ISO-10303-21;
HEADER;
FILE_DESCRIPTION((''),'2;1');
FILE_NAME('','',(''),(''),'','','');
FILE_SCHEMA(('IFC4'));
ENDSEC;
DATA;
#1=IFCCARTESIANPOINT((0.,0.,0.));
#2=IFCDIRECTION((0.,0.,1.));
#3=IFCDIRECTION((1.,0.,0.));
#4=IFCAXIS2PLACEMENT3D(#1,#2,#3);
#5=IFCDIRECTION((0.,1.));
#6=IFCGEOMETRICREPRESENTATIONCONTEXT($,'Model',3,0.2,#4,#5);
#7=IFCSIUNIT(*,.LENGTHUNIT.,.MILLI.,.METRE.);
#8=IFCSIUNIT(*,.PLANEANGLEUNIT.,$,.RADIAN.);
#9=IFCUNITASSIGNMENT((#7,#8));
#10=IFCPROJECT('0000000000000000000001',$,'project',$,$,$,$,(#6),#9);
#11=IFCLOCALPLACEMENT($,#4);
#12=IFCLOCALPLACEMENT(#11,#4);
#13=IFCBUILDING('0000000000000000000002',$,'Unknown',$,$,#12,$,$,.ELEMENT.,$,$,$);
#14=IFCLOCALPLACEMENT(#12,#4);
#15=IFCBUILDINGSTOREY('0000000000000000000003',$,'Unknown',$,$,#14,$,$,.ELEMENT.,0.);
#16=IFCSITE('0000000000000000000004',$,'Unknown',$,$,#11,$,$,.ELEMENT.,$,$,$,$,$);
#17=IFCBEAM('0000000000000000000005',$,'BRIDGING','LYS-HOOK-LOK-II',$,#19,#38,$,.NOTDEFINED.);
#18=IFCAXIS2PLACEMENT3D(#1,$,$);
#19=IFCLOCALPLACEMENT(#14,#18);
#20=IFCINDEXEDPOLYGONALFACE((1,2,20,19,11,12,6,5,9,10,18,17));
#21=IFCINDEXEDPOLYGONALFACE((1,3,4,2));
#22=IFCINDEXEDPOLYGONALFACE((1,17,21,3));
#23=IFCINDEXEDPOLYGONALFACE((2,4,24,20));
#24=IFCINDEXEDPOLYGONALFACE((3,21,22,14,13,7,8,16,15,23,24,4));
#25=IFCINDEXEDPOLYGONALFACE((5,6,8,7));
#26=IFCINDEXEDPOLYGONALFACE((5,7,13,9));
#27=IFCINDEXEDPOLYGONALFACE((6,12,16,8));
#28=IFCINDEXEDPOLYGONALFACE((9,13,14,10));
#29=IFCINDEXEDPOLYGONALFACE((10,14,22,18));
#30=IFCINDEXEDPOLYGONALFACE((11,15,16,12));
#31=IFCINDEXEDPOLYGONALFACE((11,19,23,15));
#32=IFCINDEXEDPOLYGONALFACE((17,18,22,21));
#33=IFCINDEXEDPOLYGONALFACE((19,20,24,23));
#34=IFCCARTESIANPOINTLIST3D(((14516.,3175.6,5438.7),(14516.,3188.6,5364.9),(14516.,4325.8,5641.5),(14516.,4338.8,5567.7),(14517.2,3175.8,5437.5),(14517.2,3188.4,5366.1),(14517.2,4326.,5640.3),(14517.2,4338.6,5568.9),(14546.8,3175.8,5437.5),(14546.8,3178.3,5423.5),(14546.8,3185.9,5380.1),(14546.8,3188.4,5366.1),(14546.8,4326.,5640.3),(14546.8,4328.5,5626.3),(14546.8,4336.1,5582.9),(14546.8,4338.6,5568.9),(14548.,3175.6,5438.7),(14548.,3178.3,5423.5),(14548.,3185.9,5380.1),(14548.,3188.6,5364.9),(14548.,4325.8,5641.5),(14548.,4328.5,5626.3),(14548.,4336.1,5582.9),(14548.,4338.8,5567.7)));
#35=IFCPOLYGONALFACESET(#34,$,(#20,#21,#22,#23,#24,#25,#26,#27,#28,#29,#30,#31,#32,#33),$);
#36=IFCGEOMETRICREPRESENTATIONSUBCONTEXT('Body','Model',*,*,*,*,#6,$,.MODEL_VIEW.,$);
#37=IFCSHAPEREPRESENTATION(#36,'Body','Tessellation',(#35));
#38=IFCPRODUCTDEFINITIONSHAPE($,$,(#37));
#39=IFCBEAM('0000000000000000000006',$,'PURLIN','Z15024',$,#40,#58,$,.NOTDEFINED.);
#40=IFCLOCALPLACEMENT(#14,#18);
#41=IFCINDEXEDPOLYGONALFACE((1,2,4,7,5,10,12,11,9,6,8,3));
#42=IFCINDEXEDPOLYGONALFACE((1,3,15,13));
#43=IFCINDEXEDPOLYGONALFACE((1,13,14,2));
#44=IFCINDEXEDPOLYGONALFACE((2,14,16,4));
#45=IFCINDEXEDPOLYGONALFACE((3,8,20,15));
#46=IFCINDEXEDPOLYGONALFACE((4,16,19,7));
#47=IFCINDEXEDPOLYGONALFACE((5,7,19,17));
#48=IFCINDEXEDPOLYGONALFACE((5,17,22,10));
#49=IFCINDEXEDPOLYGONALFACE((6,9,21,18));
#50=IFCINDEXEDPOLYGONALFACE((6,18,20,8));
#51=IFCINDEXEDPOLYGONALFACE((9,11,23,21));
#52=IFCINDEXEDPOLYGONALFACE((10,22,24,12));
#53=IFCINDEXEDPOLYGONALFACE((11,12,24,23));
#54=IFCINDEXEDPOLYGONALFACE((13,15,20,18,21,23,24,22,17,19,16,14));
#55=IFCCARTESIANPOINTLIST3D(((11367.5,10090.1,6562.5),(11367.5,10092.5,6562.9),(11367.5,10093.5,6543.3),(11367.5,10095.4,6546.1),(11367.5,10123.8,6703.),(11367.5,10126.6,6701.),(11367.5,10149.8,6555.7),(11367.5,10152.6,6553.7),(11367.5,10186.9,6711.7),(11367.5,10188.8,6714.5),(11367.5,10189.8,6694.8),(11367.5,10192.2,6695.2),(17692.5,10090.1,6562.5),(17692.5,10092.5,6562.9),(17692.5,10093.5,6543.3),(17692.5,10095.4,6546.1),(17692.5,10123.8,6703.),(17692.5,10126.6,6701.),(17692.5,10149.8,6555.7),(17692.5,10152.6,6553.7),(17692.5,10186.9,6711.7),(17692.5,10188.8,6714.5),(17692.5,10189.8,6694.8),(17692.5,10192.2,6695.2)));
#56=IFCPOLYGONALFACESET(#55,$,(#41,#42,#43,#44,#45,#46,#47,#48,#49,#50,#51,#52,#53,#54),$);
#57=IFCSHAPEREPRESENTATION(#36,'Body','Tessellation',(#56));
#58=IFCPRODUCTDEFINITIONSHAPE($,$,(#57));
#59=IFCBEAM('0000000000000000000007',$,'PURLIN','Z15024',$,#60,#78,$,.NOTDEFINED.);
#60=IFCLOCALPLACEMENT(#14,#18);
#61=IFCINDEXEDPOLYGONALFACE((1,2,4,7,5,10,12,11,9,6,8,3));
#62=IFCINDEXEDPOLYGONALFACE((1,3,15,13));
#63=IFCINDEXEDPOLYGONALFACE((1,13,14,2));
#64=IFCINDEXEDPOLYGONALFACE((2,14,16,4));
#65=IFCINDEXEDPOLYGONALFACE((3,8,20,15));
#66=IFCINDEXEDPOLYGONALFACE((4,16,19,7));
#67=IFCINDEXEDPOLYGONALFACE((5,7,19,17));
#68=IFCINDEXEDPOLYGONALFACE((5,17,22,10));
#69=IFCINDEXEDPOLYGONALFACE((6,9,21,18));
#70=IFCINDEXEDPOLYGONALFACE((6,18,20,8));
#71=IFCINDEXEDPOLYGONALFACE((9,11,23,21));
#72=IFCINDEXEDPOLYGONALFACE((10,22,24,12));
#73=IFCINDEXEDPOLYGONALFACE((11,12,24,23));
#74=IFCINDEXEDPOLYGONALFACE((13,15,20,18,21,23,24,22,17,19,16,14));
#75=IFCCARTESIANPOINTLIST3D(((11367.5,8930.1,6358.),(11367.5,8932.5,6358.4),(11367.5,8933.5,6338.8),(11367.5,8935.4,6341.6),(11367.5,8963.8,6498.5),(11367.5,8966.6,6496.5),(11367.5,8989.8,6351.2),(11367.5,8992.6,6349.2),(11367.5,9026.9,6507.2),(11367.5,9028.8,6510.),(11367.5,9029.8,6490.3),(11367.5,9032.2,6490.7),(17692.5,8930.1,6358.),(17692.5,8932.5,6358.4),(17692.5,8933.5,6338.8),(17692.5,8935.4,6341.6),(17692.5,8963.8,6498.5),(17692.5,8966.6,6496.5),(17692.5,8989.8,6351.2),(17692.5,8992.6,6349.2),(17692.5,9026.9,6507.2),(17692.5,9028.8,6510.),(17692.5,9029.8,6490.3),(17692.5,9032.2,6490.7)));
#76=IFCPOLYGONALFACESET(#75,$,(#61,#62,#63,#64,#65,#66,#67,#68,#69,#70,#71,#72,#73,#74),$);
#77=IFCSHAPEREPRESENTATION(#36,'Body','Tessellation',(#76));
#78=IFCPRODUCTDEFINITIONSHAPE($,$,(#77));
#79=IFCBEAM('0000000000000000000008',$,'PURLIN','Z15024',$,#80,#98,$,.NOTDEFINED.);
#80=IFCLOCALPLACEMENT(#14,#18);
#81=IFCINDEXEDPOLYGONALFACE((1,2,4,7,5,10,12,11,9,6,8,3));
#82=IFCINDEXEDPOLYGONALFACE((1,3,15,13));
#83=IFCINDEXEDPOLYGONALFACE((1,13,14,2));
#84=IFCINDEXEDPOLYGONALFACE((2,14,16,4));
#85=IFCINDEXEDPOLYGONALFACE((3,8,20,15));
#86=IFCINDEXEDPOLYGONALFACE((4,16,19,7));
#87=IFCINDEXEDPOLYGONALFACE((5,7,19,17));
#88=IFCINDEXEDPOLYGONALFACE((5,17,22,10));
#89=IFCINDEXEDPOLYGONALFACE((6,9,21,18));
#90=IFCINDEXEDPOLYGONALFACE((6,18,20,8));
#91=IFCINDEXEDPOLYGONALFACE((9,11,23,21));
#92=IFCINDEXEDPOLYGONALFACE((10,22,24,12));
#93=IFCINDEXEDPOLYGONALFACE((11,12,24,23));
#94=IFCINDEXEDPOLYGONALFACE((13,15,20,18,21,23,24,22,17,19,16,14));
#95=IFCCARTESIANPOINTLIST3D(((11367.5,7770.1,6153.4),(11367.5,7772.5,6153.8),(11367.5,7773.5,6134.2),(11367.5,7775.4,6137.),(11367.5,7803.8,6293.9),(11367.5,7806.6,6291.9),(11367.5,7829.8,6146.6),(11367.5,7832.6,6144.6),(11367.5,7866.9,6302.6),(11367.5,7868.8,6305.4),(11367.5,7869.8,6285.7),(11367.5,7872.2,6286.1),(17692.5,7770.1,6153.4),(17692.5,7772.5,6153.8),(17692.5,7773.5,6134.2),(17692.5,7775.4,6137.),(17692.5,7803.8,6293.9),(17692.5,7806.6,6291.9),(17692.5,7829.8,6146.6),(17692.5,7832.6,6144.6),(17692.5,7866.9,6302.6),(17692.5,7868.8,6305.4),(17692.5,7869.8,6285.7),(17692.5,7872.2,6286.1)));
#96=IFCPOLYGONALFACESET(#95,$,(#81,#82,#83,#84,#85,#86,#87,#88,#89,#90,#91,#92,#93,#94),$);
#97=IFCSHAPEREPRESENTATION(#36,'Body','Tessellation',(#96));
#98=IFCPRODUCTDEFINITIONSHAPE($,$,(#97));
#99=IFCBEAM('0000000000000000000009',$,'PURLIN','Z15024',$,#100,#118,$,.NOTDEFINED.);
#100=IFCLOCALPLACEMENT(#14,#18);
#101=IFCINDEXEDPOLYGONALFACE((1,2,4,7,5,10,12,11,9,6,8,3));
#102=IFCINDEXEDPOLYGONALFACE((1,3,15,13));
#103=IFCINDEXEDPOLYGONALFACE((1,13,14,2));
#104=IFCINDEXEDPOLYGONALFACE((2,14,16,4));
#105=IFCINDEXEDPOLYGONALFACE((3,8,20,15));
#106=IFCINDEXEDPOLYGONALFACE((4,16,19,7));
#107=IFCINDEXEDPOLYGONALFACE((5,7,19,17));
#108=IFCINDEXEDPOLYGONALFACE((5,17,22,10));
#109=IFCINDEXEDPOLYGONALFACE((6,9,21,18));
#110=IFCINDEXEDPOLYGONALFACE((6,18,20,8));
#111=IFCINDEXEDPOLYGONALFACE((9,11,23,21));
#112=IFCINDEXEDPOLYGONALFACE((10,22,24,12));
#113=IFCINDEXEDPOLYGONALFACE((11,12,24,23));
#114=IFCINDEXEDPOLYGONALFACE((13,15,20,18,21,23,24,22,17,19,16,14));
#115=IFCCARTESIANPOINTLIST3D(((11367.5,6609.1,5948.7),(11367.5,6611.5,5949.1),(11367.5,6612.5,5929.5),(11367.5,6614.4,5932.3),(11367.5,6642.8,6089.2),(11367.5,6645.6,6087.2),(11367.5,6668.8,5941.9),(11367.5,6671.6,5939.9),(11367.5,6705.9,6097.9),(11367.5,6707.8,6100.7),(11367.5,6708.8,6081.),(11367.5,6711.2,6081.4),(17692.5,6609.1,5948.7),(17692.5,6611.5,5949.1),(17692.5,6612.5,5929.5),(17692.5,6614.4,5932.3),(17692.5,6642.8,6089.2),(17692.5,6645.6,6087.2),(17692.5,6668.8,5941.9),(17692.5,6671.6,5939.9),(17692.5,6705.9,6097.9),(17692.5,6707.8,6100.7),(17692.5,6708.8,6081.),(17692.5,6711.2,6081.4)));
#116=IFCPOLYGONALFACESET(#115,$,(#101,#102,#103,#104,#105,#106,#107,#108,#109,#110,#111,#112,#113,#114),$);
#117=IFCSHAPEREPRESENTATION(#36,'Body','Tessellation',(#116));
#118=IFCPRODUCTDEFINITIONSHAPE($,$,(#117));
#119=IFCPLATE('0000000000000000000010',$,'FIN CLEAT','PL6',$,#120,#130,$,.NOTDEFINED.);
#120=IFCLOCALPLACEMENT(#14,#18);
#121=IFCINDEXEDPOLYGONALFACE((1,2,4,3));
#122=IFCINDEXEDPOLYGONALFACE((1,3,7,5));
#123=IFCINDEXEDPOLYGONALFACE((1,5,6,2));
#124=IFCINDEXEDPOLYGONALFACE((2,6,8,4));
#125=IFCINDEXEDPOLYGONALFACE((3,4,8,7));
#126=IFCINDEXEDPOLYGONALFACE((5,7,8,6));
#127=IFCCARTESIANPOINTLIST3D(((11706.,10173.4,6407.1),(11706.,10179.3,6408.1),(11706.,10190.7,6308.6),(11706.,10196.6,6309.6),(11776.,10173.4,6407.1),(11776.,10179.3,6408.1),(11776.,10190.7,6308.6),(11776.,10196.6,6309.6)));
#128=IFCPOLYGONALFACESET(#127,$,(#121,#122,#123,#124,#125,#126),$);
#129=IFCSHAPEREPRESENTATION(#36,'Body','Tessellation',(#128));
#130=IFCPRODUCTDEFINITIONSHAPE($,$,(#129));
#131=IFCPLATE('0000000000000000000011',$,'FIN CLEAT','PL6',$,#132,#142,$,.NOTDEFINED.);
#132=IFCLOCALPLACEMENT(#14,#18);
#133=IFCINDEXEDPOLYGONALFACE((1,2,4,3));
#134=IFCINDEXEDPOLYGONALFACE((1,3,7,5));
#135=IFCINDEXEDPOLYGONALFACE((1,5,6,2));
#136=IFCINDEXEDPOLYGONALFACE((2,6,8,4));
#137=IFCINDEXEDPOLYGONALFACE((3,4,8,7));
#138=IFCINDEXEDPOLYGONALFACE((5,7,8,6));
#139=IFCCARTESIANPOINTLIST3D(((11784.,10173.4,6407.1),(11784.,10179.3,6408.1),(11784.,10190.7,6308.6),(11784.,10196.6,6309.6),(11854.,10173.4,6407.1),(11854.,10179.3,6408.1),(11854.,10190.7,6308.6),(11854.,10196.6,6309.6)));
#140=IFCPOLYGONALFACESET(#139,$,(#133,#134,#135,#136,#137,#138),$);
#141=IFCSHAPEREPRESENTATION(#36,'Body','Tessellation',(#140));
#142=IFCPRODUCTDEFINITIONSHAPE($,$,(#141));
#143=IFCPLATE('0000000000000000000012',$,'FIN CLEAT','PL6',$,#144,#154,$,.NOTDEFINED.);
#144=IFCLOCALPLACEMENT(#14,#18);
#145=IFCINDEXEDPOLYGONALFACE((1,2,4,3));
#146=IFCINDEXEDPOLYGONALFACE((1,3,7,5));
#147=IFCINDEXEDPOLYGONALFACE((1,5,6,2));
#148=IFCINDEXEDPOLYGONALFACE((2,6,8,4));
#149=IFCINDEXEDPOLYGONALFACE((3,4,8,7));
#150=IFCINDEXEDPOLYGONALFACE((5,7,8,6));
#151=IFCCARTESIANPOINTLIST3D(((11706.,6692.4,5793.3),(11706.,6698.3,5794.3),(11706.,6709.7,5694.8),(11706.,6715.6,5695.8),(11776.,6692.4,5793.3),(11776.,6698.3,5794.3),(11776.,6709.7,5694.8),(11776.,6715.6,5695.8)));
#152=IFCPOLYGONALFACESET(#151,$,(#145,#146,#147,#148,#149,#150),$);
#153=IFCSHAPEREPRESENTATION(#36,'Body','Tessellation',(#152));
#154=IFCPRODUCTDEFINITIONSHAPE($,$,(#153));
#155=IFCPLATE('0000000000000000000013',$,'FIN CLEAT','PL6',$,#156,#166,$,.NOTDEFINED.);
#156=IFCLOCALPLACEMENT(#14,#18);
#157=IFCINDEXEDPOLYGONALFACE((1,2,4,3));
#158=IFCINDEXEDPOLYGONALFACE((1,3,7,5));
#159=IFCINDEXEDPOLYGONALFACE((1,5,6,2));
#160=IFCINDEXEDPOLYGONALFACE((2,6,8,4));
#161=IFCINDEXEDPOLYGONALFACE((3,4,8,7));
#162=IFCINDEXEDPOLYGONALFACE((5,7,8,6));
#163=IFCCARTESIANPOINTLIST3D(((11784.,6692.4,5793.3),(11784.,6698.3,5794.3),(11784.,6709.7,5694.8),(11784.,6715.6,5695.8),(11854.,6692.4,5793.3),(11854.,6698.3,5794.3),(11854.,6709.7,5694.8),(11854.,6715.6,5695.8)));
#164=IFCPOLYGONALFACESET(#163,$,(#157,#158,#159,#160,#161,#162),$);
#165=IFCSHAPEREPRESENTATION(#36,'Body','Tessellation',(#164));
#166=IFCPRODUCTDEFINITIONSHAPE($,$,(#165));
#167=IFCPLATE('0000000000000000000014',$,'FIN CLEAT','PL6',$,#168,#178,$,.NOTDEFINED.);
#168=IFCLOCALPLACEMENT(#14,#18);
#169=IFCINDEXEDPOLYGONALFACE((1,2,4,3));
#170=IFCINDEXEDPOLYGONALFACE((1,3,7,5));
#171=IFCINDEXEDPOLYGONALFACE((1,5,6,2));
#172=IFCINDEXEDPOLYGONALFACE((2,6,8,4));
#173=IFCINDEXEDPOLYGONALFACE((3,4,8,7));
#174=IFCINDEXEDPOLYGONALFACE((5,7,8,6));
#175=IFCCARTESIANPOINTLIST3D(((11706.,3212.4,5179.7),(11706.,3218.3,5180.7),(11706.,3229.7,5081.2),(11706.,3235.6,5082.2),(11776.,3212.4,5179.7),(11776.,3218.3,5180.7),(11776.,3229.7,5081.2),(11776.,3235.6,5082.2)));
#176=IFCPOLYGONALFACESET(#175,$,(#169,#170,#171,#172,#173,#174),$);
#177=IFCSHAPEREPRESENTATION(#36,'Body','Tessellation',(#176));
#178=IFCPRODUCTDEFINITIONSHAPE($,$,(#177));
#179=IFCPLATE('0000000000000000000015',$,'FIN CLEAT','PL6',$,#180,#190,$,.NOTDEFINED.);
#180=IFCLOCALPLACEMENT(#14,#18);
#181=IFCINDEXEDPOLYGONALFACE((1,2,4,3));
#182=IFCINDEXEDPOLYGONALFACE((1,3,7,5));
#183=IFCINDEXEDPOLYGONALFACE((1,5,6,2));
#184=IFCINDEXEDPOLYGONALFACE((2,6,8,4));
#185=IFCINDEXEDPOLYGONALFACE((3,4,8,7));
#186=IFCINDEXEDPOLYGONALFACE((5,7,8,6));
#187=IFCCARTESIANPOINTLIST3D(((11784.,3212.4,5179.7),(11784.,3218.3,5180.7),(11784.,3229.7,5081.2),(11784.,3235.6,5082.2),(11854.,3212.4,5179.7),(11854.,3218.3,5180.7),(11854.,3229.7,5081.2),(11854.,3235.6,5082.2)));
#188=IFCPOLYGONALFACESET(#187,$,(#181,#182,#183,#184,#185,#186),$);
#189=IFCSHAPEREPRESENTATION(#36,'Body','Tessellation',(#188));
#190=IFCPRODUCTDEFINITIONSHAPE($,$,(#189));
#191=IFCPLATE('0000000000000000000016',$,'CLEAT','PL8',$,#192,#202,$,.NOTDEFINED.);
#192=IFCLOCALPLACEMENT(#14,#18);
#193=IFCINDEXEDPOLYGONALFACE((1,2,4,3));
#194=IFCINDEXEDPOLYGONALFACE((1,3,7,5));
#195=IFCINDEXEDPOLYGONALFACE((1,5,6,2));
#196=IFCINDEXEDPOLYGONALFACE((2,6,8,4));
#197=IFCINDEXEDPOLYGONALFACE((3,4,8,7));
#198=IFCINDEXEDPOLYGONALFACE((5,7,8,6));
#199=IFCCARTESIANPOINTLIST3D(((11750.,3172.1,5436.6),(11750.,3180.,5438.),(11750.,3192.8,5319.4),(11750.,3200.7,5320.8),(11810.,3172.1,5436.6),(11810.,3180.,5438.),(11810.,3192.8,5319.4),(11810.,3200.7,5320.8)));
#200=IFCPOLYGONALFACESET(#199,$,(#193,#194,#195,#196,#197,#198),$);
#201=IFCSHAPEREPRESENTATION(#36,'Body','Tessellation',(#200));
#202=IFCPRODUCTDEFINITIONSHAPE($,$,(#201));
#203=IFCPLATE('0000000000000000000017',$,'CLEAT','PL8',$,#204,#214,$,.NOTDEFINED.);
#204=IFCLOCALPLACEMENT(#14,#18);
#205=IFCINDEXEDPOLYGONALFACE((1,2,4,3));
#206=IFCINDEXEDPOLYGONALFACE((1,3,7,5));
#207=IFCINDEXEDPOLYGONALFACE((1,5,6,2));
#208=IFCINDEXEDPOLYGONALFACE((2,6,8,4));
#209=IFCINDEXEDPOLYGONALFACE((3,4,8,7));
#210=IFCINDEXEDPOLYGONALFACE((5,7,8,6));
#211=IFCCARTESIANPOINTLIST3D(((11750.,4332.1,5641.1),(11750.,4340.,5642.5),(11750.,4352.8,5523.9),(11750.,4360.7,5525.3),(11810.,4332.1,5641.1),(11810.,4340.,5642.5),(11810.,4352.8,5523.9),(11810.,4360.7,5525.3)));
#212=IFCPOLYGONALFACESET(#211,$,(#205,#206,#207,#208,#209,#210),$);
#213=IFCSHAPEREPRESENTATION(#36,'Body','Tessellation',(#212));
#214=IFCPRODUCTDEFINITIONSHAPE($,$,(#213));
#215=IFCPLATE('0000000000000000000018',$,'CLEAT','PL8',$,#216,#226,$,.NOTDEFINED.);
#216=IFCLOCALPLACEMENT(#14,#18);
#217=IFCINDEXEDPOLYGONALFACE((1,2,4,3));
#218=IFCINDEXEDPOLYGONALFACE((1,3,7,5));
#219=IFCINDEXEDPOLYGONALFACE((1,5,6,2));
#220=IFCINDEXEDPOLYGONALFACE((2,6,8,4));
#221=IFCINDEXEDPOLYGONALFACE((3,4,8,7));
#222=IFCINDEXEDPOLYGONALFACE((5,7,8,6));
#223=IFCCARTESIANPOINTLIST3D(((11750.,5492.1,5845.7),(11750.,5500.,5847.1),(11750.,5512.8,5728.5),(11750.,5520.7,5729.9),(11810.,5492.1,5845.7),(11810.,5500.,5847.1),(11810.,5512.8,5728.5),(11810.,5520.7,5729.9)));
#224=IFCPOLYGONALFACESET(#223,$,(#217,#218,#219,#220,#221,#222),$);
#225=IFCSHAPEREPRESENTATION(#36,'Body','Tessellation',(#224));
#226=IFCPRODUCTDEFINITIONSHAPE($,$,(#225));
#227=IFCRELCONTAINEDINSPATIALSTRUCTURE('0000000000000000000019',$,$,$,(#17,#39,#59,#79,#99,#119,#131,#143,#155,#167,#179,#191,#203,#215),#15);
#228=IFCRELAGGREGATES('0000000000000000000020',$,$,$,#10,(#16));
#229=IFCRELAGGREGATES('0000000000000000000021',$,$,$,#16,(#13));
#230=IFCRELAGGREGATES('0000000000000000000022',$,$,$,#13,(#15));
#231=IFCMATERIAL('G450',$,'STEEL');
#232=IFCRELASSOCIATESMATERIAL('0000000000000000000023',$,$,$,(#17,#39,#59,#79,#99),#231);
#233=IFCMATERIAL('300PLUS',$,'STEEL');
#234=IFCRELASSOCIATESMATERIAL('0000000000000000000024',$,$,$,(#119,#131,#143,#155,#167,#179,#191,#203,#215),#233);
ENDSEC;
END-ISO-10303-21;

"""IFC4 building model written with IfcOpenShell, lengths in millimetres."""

from ifc_helpers import new_model, si_unit, direction, frame, origin_with_axes, place, context, subcontext, project, spatial, line, indexed_curve, outline, extrude, material, element, save


model = new_model("IFC4")

# Units and contexts
model_context = context("Model", 3, precision=0.2, world=origin_with_axes(), true_north=direction((0.0, 1.0)))
body_context = subcontext(model_context, "Body", "Model", "MODEL_VIEW")
ifc_project = project(units=[si_unit("LENGTHUNIT", "METRE", prefix="MILLI"), si_unit("PLANEANGLEUNIT", "RADIAN")], contexts=[model_context])

# Site, building, storey
site_placement = place(None, origin_with_axes())
site = spatial("IfcSite", under=ifc_project, at=site_placement, Name="Unknown", CompositionType="ELEMENT")
building_placement = place(site_placement, origin_with_axes())
building = spatial("IfcBuilding", under=site, at=building_placement, Name="Unknown", CompositionType="ELEMENT")
storey_placement = place(building_placement, origin_with_axes())
storey = spatial("IfcBuildingStorey", under=building, at=storey_placement, Name="Unknown", CompositionType="ELEMENT", Elevation=0.0)

# Shared definitions
ifc_material_1 = material(Name="300PLUS", Category="STEEL")

# Beams
ifc_material_2 = material(Name="G450", Category="STEEL")
beam_1_placement = place(storey_placement, frame((14532.0, 3182.1, 5401.8), z_axis=(1.0, 0.0, 0.0), x_axis=(0.0, 0.984809, 0.173639)))
element("IfcBeam", 1, at=beam_1_placement, inside=storey, material=ifc_material_2, Name="BRIDGING", Description="LYS-HOOK-LOK-II", PredefinedType="NOTDEFINED", context=body_context, shape_type="SolidModel", body=[
    extrude(outline(indexed_curve([(16.0, -37.5), (16.0, -22.0), (14.8, -22.0), (14.8, -36.3), (-14.8, -36.3), (-14.8, 36.3), (14.8, 36.3), (14.8, 22.0), (16.0, 22.0), (16.0, 37.5), (-16.0, 37.5), (-16.0, -37.5)], segments=[line(1, 2, 3, 4, 5, 6, 7, 8, 9, 10, 11, 12, 1)])), frame((0.0, 0.0, 0.0), z_axis=(-1.0, 0.0, 0.0), x_axis=(0.0, 0.0, 1.0)), (0.0, 0.0, -1.0), 1167.9),
])
for number, where, z_axis, x_axis, name in (
    (2, (11367.5, 10138.2, 6628.4), (0.0, -0.984808, -0.173648), (1.0, 0.0, 0.0), "PURLIN"),
    (3, (11367.5, 8978.2, 6423.9), (0.0, -0.984808, -0.173648), (1.0, 0.0, 0.0), "PURLIN"),
    (4, (11367.5, 7818.2, 6219.3), (0.0, -0.984808, -0.173648), (1.0, 0.0, 0.0), "PURLIN"),
    (5, (11367.5, 6657.2, 6014.6), (0.0, -0.984808, -0.173648), (1.0, 0.0, 0.0), "PURLIN"),
):
    element("IfcBeam", number, at=place(storey_placement, frame(where, z_axis=z_axis, x_axis=x_axis)), inside=storey, material=ifc_material_2, Name=name, Description="Z15024", PredefinedType="NOTDEFINED", context=body_context, shape_type="SolidModel", body=[
        extrude(outline(indexed_curve([(58.8, -76.0), (58.8, -56.5), (56.4, -56.5), (56.4, -73.6), (1.2, -73.6), (1.2, 76.0), (-64.8, 76.0), (-64.8, 56.5), (-62.4, 56.5), (-62.4, 73.6), (-1.2, 73.6), (-1.2, -76.0)], segments=[line(1, 2, 3, 4, 5, 6, 7, 8, 9, 10, 11, 12, 1)])), frame((0.0, 0.0, 0.0), z_axis=(-1.0, 0.0, 0.0), x_axis=(0.0, 0.0, 1.0)), (0.0, 0.0, -1.0), 6325.0),
    ])

# Plates
for number, where, z_axis, x_axis, name in (
    (6, (11706.0, 10176.4, 6407.6), (0.0, 0.984924, 0.172987), (1.0, 0.0, 0.0), "FIN CLEAT"),
    (7, (11784.0, 10176.4, 6407.6), (0.0, 0.984924, 0.172987), (1.0, 0.0, 0.0), "FIN CLEAT"),
    (8, (11706.0, 6695.4, 5793.8), (0.0, 0.984924, 0.172987), (1.0, 0.0, 0.0), "FIN CLEAT"),
    (9, (11784.0, 6695.4, 5793.8), (0.0, 0.984924, 0.172987), (1.0, 0.0, 0.0), "FIN CLEAT"),
    (10, (11706.0, 3215.4, 5180.2), (0.0, 0.984924, 0.172987), (1.0, 0.0, 0.0), "FIN CLEAT"),
    (11, (11784.0, 3215.4, 5180.2), (0.0, 0.984924, 0.172987), (1.0, 0.0, 0.0), "FIN CLEAT"),
):
    element("IfcPlate", number, at=place(storey_placement, frame(where, z_axis=z_axis, x_axis=x_axis)), inside=storey, material=ifc_material_1, Name=name, Description="PL6", PredefinedType="NOTDEFINED", context=body_context, shape_type="SolidModel", body=[
        extrude(outline(indexed_curve([(0.0, 0.0), (70.0, 0.0), (70.0, 100.0), (0.0, 100.0)], segments=[line(1, 2, 3, 4, 1)])), frame((0.0, 0.0, 3.0), z_axis=(0.0, 0.0, 1.0), x_axis=(1.0, 0.0, 0.0)), (0.0, 0.0, -1.0), 6.0),
    ])
for number, where, z_axis, x_axis, name in (
    (12, (11810.0, 3196.7, 5320.1), (0.0, 0.984758, 0.173929), (-1.0, 0.0, 0.0), "CLEAT"),
    (13, (11810.0, 4356.7, 5524.6), (0.0, 0.984758, 0.173929), (-1.0, 0.0, 0.0), "CLEAT"),
    (14, (11810.0, 5516.7, 5729.2), (0.0, 0.984758, 0.173929), (-1.0, 0.0, 0.0), "CLEAT"),
):
    element("IfcPlate", number, at=place(storey_placement, frame(where, z_axis=z_axis, x_axis=x_axis)), inside=storey, material=ifc_material_1, Name=name, Description="PL8", PredefinedType="NOTDEFINED", context=body_context, shape_type="SolidModel", body=[
        extrude(outline(indexed_curve([(0.0, 0.0), (60.0, 0.0), (60.0, 119.0), (0.0, 119.0)], segments=[line(1, 2, 3, 4, 1)])), frame((0.0, 0.0, 4.0), z_axis=(0.0, 0.0, 1.0), x_axis=(1.0, 0.0, 0.0)), (0.0, 0.0, -1.0), 8.0),
    ])

save(model, "model.ifc")
